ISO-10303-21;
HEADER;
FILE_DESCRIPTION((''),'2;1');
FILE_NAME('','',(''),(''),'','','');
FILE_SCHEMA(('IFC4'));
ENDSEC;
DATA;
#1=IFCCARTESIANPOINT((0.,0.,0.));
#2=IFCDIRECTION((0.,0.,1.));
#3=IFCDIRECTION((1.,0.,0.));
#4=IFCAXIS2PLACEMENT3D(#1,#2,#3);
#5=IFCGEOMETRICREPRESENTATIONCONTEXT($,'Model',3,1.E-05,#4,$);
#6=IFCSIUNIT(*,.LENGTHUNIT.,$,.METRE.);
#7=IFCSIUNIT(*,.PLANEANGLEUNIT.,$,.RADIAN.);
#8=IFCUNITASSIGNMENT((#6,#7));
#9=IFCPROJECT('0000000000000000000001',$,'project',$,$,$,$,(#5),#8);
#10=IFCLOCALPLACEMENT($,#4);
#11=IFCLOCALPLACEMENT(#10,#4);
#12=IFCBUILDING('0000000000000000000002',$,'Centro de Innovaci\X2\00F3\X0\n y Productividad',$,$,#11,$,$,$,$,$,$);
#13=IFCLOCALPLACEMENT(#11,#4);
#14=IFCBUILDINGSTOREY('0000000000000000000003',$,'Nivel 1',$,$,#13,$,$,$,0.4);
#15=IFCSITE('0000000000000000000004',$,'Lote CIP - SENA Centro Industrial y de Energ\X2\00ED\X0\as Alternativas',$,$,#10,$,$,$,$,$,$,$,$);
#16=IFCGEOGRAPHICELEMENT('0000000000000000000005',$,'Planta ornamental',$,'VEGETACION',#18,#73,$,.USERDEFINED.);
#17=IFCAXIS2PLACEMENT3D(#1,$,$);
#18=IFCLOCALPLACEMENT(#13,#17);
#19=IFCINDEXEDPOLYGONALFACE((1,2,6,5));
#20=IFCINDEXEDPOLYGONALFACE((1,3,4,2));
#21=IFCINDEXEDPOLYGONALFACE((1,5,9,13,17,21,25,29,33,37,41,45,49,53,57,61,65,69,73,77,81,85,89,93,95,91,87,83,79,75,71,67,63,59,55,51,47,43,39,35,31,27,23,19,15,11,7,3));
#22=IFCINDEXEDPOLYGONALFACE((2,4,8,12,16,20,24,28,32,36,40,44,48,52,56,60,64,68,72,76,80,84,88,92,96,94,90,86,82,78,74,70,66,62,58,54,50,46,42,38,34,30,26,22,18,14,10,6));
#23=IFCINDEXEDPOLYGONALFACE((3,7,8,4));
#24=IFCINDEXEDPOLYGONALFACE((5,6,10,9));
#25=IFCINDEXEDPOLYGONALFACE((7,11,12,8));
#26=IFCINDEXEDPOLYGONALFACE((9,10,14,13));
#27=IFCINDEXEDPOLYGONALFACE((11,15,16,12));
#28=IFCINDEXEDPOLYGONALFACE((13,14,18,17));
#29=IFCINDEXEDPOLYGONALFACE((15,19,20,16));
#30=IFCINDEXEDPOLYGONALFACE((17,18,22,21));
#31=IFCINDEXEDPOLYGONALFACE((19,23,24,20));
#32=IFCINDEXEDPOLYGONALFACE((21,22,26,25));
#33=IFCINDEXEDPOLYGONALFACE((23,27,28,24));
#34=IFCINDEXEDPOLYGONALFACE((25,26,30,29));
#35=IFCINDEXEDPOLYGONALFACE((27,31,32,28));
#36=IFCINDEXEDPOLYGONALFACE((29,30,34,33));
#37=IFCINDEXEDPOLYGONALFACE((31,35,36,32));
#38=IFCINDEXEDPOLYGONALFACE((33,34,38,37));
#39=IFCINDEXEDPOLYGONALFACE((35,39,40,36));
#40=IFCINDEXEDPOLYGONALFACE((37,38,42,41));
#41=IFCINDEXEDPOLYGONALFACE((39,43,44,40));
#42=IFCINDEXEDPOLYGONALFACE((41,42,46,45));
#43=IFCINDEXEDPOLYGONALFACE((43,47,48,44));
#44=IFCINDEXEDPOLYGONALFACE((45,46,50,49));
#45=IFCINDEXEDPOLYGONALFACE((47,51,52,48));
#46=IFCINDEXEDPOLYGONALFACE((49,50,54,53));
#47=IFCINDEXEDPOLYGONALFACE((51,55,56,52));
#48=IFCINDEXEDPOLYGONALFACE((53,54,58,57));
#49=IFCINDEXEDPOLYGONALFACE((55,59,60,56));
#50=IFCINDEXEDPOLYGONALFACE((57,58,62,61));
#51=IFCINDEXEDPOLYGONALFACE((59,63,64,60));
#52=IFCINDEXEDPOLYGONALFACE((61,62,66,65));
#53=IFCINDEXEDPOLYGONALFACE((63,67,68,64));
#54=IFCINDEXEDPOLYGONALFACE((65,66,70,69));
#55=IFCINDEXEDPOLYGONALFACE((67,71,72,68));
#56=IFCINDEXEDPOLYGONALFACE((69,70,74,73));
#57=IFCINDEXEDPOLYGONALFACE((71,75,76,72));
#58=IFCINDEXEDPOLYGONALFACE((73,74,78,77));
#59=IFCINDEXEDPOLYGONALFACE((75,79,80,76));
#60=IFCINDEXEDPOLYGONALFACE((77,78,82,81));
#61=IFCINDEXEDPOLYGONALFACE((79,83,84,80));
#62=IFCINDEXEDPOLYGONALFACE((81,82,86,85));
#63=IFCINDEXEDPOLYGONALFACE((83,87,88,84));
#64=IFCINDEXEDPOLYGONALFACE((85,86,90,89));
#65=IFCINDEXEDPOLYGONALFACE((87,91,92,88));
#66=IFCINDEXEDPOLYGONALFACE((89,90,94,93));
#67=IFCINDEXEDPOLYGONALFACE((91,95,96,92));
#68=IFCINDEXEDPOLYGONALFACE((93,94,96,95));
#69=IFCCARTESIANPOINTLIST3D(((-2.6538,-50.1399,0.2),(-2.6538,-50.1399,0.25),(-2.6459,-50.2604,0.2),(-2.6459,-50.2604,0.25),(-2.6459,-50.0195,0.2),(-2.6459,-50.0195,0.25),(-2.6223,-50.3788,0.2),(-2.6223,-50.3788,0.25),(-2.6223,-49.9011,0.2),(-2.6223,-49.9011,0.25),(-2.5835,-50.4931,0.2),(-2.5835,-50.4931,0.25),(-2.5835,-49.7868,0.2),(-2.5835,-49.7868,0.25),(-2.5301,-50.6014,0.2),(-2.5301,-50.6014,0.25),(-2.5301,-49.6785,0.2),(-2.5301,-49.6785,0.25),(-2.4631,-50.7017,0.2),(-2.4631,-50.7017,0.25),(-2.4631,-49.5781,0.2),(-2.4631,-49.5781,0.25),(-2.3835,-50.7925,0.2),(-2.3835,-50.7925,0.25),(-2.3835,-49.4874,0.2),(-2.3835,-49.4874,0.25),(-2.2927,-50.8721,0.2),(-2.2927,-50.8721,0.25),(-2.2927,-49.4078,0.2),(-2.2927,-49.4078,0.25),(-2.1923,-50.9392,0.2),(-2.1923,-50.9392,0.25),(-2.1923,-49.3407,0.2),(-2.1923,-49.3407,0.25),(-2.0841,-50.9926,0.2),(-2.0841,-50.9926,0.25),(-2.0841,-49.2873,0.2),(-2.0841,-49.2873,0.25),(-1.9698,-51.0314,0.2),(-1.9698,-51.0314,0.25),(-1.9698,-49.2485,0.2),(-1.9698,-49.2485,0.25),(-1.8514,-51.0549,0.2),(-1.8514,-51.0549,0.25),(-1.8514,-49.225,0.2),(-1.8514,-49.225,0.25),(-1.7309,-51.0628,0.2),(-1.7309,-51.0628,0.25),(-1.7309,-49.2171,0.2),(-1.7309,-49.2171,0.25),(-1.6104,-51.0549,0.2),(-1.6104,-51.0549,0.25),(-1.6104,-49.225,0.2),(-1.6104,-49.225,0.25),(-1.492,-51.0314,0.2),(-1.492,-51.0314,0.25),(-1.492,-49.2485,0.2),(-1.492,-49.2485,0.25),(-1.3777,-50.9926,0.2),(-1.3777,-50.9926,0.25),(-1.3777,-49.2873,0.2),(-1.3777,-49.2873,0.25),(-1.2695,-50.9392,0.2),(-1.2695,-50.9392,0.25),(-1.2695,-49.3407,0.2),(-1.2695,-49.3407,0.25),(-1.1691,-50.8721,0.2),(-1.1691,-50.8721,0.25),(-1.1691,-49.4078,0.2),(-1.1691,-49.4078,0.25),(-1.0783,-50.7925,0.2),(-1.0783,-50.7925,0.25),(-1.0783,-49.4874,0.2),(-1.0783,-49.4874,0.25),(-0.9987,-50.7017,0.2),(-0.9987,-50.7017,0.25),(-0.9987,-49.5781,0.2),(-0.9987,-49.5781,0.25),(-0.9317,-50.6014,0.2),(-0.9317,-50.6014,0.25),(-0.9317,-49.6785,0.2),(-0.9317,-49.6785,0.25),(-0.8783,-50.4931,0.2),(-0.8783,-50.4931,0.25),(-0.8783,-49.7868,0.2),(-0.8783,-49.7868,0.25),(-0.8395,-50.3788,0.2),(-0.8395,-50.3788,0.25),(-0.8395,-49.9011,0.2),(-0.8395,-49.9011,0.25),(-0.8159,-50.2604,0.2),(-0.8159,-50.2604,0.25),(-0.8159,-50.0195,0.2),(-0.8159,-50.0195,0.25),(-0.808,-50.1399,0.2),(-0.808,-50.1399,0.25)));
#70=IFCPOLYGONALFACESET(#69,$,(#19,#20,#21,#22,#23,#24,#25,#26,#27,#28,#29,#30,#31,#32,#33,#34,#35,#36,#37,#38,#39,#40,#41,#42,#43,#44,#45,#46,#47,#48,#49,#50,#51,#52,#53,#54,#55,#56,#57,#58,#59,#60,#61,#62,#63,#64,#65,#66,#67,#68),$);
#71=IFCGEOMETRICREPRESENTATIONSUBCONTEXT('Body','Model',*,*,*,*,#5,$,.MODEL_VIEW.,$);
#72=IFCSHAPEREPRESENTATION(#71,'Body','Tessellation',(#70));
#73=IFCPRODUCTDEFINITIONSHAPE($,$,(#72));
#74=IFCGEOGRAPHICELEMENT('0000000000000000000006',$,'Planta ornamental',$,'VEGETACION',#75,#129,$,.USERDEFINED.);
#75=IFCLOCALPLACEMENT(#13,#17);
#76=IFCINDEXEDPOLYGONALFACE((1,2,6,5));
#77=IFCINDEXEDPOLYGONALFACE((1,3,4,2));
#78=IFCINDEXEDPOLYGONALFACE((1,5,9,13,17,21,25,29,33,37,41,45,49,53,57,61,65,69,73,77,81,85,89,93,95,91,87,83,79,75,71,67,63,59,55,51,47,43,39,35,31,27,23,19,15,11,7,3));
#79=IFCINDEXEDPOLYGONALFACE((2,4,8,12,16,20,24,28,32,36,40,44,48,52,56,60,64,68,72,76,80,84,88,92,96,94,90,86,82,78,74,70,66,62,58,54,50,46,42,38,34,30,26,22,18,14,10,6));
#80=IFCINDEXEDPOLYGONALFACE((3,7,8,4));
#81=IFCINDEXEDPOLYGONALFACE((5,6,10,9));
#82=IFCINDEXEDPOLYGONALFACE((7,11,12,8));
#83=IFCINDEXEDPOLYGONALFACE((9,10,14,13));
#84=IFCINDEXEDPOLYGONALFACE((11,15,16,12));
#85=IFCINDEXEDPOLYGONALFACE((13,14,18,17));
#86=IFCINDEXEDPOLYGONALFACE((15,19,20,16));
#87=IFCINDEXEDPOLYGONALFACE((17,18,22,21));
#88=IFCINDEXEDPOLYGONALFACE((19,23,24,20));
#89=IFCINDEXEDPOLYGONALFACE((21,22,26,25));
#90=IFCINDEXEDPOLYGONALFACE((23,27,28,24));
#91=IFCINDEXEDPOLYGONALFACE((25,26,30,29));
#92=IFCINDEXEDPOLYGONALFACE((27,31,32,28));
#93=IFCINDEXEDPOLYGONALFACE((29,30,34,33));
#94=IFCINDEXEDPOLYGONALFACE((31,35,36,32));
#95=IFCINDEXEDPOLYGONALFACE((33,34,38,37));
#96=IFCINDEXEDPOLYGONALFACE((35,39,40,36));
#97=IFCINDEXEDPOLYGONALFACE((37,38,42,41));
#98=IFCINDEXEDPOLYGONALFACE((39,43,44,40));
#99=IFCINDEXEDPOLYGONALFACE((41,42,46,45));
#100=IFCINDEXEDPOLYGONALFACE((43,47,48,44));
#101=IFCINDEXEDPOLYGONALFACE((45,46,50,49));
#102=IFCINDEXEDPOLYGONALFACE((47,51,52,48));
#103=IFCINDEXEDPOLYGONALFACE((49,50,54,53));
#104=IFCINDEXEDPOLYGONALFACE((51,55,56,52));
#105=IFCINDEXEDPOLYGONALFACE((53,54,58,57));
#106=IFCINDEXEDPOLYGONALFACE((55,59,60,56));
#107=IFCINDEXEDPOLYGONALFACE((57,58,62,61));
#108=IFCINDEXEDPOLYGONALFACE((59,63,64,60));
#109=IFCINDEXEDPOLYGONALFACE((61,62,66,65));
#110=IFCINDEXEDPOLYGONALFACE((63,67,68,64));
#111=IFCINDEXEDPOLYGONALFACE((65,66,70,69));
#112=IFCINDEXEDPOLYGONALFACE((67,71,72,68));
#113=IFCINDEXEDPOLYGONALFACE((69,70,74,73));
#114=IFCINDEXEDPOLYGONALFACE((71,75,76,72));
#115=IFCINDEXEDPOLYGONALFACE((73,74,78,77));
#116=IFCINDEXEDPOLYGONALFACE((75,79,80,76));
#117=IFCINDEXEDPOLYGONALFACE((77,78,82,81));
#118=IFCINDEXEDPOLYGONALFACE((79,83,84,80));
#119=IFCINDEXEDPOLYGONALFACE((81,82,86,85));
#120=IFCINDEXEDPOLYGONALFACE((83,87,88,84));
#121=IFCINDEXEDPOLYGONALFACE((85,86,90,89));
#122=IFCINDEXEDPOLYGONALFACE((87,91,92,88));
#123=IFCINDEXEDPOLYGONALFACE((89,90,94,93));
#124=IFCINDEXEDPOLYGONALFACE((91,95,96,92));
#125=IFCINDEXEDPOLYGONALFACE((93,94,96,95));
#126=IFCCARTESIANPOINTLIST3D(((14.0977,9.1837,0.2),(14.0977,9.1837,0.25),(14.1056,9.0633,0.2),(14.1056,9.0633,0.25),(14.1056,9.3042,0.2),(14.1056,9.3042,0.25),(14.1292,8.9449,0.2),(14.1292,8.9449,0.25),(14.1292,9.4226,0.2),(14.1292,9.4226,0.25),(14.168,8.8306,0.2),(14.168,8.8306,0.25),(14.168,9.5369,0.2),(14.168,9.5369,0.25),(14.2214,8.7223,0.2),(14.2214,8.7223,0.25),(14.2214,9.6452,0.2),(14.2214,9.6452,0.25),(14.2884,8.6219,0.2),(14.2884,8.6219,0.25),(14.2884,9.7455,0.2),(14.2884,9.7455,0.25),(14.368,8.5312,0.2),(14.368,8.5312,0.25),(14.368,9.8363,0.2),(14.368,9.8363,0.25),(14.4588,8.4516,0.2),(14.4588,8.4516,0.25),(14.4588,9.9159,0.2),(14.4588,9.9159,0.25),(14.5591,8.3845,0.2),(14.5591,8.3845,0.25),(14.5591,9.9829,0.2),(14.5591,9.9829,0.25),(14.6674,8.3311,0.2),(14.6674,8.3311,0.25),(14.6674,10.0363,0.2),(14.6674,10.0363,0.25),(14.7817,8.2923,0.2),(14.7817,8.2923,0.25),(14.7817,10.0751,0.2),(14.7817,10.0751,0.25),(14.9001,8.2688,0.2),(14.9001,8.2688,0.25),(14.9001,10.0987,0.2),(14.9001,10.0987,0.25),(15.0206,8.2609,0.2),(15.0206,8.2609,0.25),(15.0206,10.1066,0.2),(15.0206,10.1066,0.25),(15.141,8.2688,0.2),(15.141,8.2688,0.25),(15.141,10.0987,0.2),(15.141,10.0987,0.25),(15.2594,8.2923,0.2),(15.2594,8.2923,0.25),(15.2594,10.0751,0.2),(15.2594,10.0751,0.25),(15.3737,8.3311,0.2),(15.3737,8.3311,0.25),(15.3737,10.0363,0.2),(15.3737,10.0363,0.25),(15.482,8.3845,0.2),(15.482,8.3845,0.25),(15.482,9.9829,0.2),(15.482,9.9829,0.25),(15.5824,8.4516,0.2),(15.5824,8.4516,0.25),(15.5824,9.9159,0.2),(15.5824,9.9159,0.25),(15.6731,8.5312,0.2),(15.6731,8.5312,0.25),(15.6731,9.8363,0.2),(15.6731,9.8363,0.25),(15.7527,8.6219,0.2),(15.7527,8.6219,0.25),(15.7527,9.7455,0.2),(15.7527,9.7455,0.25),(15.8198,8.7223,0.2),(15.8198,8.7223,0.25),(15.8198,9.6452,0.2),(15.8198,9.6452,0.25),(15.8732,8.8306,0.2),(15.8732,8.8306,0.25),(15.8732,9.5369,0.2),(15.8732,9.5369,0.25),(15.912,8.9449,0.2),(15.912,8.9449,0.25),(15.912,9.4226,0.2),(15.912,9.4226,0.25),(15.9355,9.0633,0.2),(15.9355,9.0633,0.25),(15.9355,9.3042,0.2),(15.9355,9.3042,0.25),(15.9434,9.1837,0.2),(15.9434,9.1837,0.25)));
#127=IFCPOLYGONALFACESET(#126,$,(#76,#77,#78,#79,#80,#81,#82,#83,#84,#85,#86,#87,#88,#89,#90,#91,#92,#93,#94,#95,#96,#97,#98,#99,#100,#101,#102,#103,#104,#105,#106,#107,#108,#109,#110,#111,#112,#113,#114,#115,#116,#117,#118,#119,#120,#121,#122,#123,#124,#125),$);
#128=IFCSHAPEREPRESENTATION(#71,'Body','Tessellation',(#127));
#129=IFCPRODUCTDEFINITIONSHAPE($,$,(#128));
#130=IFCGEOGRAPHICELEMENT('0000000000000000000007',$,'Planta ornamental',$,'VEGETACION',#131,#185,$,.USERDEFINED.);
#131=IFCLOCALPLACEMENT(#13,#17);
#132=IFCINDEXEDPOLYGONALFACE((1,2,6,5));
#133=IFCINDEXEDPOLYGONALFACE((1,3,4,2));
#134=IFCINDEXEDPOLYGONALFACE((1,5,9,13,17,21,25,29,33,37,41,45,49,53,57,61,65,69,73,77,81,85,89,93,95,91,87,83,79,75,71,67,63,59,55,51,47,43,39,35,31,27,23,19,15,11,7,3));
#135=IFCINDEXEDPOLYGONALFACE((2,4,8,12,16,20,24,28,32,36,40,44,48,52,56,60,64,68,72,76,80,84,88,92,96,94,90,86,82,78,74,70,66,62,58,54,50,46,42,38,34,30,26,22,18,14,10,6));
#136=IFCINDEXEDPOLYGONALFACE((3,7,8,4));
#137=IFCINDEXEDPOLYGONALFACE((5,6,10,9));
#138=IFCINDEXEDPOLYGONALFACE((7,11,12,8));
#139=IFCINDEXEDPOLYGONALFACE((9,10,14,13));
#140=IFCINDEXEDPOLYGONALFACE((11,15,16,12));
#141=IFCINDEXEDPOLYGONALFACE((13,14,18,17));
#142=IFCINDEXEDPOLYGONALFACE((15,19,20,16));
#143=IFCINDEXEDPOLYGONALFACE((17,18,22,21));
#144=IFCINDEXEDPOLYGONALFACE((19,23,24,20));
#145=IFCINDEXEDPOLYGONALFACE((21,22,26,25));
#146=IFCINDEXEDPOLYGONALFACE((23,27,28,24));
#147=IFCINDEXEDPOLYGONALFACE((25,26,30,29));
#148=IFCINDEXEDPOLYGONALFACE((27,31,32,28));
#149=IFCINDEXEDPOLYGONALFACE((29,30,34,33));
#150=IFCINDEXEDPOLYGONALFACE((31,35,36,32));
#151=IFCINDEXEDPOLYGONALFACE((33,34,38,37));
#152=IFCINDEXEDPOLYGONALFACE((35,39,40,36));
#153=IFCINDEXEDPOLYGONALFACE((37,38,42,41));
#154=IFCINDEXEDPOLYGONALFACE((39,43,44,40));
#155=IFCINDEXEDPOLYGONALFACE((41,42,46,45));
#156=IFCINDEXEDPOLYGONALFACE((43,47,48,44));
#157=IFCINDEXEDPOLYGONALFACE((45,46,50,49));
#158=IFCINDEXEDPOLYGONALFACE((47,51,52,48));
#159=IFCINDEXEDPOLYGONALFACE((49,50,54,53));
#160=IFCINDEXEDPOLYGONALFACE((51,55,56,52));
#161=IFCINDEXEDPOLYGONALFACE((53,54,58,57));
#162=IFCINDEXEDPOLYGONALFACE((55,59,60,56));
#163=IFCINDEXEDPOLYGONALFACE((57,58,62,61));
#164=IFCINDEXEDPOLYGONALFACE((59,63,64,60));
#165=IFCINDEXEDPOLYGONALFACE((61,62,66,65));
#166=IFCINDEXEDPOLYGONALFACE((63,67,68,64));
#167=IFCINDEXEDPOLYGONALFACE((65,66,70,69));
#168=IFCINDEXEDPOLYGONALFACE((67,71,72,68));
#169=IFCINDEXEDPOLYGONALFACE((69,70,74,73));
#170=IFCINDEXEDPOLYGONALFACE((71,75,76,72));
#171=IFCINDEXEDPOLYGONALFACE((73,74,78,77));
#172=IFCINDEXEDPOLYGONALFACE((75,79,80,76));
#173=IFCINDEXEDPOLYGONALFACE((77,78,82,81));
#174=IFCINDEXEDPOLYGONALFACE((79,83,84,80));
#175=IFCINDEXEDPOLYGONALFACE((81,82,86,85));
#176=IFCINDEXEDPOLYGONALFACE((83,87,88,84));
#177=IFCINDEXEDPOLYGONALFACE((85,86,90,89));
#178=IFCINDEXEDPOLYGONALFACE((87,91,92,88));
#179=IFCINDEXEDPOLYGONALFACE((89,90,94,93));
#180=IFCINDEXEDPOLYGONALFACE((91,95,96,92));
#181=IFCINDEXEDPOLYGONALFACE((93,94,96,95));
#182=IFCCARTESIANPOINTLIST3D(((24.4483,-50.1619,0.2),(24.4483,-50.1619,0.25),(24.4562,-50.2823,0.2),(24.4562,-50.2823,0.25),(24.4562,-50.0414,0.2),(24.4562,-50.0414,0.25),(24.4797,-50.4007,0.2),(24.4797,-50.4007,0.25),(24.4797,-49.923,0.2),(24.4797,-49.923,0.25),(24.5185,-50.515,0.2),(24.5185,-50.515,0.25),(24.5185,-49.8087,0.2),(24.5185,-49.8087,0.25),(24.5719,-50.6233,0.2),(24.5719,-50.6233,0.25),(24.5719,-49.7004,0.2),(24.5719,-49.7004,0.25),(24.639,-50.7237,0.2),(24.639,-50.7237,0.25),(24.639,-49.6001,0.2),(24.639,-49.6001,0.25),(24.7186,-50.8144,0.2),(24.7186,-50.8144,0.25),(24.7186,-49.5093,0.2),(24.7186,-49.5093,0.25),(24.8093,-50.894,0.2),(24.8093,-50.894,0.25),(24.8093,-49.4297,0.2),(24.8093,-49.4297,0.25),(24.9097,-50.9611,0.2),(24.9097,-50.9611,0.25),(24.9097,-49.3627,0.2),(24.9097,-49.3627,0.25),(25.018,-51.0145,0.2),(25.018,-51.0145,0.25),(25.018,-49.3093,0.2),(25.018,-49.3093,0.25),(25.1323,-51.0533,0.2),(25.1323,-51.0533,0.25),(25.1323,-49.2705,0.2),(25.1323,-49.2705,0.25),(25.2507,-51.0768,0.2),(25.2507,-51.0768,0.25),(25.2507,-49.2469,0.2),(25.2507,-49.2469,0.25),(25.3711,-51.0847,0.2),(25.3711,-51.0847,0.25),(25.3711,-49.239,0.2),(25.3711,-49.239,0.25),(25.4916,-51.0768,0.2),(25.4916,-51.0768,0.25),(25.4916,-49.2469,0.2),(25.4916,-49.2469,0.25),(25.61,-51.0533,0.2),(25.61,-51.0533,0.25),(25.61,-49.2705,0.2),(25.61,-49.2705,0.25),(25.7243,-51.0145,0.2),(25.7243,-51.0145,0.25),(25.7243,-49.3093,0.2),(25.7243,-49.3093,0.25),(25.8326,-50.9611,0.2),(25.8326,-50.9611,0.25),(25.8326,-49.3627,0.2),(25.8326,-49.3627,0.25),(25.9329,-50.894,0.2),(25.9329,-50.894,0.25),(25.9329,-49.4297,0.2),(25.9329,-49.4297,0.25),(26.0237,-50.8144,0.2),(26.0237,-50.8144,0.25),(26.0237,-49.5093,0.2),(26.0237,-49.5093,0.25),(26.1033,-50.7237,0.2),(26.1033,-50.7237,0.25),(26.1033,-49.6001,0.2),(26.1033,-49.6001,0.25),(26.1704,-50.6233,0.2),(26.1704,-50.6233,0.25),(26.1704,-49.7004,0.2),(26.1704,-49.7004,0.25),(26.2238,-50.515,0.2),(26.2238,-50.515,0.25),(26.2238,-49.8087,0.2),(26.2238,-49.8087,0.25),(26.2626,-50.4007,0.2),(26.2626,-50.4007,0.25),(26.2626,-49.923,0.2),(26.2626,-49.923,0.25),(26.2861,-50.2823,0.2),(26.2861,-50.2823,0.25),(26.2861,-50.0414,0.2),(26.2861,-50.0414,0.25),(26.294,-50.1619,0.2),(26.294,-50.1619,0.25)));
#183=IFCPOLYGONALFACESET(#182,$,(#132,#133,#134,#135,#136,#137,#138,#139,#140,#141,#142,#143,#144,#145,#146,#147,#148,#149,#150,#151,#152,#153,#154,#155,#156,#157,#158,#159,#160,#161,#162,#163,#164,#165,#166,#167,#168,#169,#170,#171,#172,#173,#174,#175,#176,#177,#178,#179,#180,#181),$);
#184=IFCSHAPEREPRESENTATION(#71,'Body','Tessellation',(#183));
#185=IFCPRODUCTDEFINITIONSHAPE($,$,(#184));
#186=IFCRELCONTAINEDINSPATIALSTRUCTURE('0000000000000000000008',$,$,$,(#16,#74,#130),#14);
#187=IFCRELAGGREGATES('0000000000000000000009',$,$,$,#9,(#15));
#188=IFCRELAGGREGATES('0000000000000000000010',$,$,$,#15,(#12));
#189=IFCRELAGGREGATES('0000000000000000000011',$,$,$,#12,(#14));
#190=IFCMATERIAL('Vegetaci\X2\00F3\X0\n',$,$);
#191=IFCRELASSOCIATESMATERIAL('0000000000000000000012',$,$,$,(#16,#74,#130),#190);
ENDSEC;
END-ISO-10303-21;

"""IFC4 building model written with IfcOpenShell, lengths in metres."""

from ifc_helpers import new_model, si_unit, frame, origin_with_axes, place, context, subcontext, project, spatial, polyline, outline, extrude, material, element, save


model = new_model("IFC4")

# Units and contexts
model_context = context("Model", 3, precision=1e-05, world=origin_with_axes())
body_context = subcontext(model_context, "Body", "Model", "MODEL_VIEW")
ifc_project = project(units=[si_unit("LENGTHUNIT", "METRE"), si_unit("PLANEANGLEUNIT", "RADIAN")], contexts=[model_context])

# Site, building, storey
site_placement = place(None, origin_with_axes())
site = spatial("IfcSite", under=ifc_project, at=site_placement, Name="Lote CIP - SENA Centro Industrial y de Energías Alternativas")
building_placement = place(site_placement, origin_with_axes())
building = spatial("IfcBuilding", under=site, at=building_placement, Name="Centro de Innovación y Productividad")
storey_placement = place(building_placement, origin_with_axes())
storey = spatial("IfcBuildingStorey", under=building, at=storey_placement, Name="Nivel 1", Elevation=0.4)

# Geographic elements
ifc_material = material(Name="Vegetación")
geographic_element_1_placement = place(storey_placement, origin_with_axes())
element("IfcGeographicElement", 1, at=geographic_element_1_placement, inside=storey, material=ifc_material, Name="Planta ornamental", ObjectType="VEGETACION", PredefinedType="USERDEFINED", context=body_context, shape_type="SweptSolid", body=[
    extrude(outline(polyline([(-0.808, -50.1399), (-0.8159, -50.2604), (-0.8395, -50.3788), (-0.8783, -50.4931), (-0.9317, -50.6014), (-0.9987, -50.7017), (-1.0783, -50.7925), (-1.1691, -50.8721), (-1.2695, -50.9392), (-1.3777, -50.9926), (-1.492, -51.0314), (-1.6104, -51.0549), (-1.7309, -51.0628), (-1.8514, -51.0549), (-1.9698, -51.0314), (-2.0841, -50.9926), (-2.1923, -50.9392), (-2.2927, -50.8721), (-2.3835, -50.7925), (-2.4631, -50.7017), (-2.5301, -50.6014), (-2.5835, -50.4931), (-2.6223, -50.3788), (-2.6459, -50.2604), (-2.6538, -50.1399), (-2.6459, -50.0195), (-2.6223, -49.9011), (-2.5835, -49.7868), (-2.5301, -49.6785), (-2.4631, -49.5781), (-2.3835, -49.4874), (-2.2927, -49.4078), (-2.1923, -49.3407), (-2.0841, -49.2873), (-1.9698, -49.2485), (-1.8514, -49.225), (-1.7309, -49.2171), (-1.6104, -49.225), (-1.492, -49.2485), (-1.3777, -49.2873), (-1.2695, -49.3407), (-1.1691, -49.4078), (-1.0783, -49.4874), (-0.9987, -49.5781), (-0.9317, -49.6785), (-0.8783, -49.7868), (-0.8395, -49.9011), (-0.8159, -50.0195), (-0.808, -50.1399)])), frame((0.0, 0.0, 0.2)), (0.0, 0.0, 1.0), 0.05),
])
geographic_element_2_placement = place(storey_placement, origin_with_axes())
element("IfcGeographicElement", 2, at=geographic_element_2_placement, inside=storey, material=ifc_material, Name="Planta ornamental", ObjectType="VEGETACION", PredefinedType="USERDEFINED", context=body_context, shape_type="SweptSolid", body=[
    extrude(outline(polyline([(15.9434, 9.1837), (15.9355, 9.0633), (15.912, 8.9449), (15.8732, 8.8306), (15.8198, 8.7223), (15.7527, 8.6219), (15.6731, 8.5312), (15.5824, 8.4516), (15.482, 8.3845), (15.3737, 8.3311), (15.2594, 8.2923), (15.141, 8.2688), (15.0206, 8.2609), (14.9001, 8.2688), (14.7817, 8.2923), (14.6674, 8.3311), (14.5591, 8.3845), (14.4588, 8.4516), (14.368, 8.5312), (14.2884, 8.6219), (14.2214, 8.7223), (14.168, 8.8306), (14.1292, 8.9449), (14.1056, 9.0633), (14.0977, 9.1837), (14.1056, 9.3042), (14.1292, 9.4226), (14.168, 9.5369), (14.2214, 9.6452), (14.2884, 9.7455), (14.368, 9.8363), (14.4588, 9.9159), (14.5591, 9.9829), (14.6674, 10.0363), (14.7817, 10.0751), (14.9001, 10.0987), (15.0206, 10.1066), (15.141, 10.0987), (15.2594, 10.0751), (15.3737, 10.0363), (15.482, 9.9829), (15.5824, 9.9159), (15.6731, 9.8363), (15.7527, 9.7455), (15.8198, 9.6452), (15.8732, 9.5369), (15.912, 9.4226), (15.9355, 9.3042), (15.9434, 9.1837)])), frame((0.0, 0.0, 0.2)), (0.0, 0.0, 1.0), 0.05),
])
geographic_element_3_placement = place(storey_placement, origin_with_axes())
element("IfcGeographicElement", 3, at=geographic_element_3_placement, inside=storey, material=ifc_material, Name="Planta ornamental", ObjectType="VEGETACION", PredefinedType="USERDEFINED", context=body_context, shape_type="SweptSolid", body=[
    extrude(outline(polyline([(26.294, -50.1619), (26.2861, -50.2823), (26.2626, -50.4007), (26.2238, -50.515), (26.1704, -50.6233), (26.1033, -50.7237), (26.0237, -50.8144), (25.9329, -50.894), (25.8326, -50.9611), (25.7243, -51.0145), (25.61, -51.0533), (25.4916, -51.0768), (25.3711, -51.0847), (25.2507, -51.0768), (25.1323, -51.0533), (25.018, -51.0145), (24.9097, -50.9611), (24.8093, -50.894), (24.7186, -50.8144), (24.639, -50.7237), (24.5719, -50.6233), (24.5185, -50.515), (24.4797, -50.4007), (24.4562, -50.2823), (24.4483, -50.1619), (24.4562, -50.0414), (24.4797, -49.923), (24.5185, -49.8087), (24.5719, -49.7004), (24.639, -49.6001), (24.7186, -49.5093), (24.8093, -49.4297), (24.9097, -49.3627), (25.018, -49.3093), (25.1323, -49.2705), (25.2507, -49.2469), (25.3711, -49.239), (25.4916, -49.2469), (25.61, -49.2705), (25.7243, -49.3093), (25.8326, -49.3627), (25.9329, -49.4297), (26.0237, -49.5093), (26.1033, -49.6001), (26.1704, -49.7004), (26.2238, -49.8087), (26.2626, -49.923), (26.2861, -50.0414), (26.294, -50.1619)])), frame((0.0, 0.0, 0.2)), (0.0, 0.0, 1.0), 0.05),
])

save(model, "model.ifc")
